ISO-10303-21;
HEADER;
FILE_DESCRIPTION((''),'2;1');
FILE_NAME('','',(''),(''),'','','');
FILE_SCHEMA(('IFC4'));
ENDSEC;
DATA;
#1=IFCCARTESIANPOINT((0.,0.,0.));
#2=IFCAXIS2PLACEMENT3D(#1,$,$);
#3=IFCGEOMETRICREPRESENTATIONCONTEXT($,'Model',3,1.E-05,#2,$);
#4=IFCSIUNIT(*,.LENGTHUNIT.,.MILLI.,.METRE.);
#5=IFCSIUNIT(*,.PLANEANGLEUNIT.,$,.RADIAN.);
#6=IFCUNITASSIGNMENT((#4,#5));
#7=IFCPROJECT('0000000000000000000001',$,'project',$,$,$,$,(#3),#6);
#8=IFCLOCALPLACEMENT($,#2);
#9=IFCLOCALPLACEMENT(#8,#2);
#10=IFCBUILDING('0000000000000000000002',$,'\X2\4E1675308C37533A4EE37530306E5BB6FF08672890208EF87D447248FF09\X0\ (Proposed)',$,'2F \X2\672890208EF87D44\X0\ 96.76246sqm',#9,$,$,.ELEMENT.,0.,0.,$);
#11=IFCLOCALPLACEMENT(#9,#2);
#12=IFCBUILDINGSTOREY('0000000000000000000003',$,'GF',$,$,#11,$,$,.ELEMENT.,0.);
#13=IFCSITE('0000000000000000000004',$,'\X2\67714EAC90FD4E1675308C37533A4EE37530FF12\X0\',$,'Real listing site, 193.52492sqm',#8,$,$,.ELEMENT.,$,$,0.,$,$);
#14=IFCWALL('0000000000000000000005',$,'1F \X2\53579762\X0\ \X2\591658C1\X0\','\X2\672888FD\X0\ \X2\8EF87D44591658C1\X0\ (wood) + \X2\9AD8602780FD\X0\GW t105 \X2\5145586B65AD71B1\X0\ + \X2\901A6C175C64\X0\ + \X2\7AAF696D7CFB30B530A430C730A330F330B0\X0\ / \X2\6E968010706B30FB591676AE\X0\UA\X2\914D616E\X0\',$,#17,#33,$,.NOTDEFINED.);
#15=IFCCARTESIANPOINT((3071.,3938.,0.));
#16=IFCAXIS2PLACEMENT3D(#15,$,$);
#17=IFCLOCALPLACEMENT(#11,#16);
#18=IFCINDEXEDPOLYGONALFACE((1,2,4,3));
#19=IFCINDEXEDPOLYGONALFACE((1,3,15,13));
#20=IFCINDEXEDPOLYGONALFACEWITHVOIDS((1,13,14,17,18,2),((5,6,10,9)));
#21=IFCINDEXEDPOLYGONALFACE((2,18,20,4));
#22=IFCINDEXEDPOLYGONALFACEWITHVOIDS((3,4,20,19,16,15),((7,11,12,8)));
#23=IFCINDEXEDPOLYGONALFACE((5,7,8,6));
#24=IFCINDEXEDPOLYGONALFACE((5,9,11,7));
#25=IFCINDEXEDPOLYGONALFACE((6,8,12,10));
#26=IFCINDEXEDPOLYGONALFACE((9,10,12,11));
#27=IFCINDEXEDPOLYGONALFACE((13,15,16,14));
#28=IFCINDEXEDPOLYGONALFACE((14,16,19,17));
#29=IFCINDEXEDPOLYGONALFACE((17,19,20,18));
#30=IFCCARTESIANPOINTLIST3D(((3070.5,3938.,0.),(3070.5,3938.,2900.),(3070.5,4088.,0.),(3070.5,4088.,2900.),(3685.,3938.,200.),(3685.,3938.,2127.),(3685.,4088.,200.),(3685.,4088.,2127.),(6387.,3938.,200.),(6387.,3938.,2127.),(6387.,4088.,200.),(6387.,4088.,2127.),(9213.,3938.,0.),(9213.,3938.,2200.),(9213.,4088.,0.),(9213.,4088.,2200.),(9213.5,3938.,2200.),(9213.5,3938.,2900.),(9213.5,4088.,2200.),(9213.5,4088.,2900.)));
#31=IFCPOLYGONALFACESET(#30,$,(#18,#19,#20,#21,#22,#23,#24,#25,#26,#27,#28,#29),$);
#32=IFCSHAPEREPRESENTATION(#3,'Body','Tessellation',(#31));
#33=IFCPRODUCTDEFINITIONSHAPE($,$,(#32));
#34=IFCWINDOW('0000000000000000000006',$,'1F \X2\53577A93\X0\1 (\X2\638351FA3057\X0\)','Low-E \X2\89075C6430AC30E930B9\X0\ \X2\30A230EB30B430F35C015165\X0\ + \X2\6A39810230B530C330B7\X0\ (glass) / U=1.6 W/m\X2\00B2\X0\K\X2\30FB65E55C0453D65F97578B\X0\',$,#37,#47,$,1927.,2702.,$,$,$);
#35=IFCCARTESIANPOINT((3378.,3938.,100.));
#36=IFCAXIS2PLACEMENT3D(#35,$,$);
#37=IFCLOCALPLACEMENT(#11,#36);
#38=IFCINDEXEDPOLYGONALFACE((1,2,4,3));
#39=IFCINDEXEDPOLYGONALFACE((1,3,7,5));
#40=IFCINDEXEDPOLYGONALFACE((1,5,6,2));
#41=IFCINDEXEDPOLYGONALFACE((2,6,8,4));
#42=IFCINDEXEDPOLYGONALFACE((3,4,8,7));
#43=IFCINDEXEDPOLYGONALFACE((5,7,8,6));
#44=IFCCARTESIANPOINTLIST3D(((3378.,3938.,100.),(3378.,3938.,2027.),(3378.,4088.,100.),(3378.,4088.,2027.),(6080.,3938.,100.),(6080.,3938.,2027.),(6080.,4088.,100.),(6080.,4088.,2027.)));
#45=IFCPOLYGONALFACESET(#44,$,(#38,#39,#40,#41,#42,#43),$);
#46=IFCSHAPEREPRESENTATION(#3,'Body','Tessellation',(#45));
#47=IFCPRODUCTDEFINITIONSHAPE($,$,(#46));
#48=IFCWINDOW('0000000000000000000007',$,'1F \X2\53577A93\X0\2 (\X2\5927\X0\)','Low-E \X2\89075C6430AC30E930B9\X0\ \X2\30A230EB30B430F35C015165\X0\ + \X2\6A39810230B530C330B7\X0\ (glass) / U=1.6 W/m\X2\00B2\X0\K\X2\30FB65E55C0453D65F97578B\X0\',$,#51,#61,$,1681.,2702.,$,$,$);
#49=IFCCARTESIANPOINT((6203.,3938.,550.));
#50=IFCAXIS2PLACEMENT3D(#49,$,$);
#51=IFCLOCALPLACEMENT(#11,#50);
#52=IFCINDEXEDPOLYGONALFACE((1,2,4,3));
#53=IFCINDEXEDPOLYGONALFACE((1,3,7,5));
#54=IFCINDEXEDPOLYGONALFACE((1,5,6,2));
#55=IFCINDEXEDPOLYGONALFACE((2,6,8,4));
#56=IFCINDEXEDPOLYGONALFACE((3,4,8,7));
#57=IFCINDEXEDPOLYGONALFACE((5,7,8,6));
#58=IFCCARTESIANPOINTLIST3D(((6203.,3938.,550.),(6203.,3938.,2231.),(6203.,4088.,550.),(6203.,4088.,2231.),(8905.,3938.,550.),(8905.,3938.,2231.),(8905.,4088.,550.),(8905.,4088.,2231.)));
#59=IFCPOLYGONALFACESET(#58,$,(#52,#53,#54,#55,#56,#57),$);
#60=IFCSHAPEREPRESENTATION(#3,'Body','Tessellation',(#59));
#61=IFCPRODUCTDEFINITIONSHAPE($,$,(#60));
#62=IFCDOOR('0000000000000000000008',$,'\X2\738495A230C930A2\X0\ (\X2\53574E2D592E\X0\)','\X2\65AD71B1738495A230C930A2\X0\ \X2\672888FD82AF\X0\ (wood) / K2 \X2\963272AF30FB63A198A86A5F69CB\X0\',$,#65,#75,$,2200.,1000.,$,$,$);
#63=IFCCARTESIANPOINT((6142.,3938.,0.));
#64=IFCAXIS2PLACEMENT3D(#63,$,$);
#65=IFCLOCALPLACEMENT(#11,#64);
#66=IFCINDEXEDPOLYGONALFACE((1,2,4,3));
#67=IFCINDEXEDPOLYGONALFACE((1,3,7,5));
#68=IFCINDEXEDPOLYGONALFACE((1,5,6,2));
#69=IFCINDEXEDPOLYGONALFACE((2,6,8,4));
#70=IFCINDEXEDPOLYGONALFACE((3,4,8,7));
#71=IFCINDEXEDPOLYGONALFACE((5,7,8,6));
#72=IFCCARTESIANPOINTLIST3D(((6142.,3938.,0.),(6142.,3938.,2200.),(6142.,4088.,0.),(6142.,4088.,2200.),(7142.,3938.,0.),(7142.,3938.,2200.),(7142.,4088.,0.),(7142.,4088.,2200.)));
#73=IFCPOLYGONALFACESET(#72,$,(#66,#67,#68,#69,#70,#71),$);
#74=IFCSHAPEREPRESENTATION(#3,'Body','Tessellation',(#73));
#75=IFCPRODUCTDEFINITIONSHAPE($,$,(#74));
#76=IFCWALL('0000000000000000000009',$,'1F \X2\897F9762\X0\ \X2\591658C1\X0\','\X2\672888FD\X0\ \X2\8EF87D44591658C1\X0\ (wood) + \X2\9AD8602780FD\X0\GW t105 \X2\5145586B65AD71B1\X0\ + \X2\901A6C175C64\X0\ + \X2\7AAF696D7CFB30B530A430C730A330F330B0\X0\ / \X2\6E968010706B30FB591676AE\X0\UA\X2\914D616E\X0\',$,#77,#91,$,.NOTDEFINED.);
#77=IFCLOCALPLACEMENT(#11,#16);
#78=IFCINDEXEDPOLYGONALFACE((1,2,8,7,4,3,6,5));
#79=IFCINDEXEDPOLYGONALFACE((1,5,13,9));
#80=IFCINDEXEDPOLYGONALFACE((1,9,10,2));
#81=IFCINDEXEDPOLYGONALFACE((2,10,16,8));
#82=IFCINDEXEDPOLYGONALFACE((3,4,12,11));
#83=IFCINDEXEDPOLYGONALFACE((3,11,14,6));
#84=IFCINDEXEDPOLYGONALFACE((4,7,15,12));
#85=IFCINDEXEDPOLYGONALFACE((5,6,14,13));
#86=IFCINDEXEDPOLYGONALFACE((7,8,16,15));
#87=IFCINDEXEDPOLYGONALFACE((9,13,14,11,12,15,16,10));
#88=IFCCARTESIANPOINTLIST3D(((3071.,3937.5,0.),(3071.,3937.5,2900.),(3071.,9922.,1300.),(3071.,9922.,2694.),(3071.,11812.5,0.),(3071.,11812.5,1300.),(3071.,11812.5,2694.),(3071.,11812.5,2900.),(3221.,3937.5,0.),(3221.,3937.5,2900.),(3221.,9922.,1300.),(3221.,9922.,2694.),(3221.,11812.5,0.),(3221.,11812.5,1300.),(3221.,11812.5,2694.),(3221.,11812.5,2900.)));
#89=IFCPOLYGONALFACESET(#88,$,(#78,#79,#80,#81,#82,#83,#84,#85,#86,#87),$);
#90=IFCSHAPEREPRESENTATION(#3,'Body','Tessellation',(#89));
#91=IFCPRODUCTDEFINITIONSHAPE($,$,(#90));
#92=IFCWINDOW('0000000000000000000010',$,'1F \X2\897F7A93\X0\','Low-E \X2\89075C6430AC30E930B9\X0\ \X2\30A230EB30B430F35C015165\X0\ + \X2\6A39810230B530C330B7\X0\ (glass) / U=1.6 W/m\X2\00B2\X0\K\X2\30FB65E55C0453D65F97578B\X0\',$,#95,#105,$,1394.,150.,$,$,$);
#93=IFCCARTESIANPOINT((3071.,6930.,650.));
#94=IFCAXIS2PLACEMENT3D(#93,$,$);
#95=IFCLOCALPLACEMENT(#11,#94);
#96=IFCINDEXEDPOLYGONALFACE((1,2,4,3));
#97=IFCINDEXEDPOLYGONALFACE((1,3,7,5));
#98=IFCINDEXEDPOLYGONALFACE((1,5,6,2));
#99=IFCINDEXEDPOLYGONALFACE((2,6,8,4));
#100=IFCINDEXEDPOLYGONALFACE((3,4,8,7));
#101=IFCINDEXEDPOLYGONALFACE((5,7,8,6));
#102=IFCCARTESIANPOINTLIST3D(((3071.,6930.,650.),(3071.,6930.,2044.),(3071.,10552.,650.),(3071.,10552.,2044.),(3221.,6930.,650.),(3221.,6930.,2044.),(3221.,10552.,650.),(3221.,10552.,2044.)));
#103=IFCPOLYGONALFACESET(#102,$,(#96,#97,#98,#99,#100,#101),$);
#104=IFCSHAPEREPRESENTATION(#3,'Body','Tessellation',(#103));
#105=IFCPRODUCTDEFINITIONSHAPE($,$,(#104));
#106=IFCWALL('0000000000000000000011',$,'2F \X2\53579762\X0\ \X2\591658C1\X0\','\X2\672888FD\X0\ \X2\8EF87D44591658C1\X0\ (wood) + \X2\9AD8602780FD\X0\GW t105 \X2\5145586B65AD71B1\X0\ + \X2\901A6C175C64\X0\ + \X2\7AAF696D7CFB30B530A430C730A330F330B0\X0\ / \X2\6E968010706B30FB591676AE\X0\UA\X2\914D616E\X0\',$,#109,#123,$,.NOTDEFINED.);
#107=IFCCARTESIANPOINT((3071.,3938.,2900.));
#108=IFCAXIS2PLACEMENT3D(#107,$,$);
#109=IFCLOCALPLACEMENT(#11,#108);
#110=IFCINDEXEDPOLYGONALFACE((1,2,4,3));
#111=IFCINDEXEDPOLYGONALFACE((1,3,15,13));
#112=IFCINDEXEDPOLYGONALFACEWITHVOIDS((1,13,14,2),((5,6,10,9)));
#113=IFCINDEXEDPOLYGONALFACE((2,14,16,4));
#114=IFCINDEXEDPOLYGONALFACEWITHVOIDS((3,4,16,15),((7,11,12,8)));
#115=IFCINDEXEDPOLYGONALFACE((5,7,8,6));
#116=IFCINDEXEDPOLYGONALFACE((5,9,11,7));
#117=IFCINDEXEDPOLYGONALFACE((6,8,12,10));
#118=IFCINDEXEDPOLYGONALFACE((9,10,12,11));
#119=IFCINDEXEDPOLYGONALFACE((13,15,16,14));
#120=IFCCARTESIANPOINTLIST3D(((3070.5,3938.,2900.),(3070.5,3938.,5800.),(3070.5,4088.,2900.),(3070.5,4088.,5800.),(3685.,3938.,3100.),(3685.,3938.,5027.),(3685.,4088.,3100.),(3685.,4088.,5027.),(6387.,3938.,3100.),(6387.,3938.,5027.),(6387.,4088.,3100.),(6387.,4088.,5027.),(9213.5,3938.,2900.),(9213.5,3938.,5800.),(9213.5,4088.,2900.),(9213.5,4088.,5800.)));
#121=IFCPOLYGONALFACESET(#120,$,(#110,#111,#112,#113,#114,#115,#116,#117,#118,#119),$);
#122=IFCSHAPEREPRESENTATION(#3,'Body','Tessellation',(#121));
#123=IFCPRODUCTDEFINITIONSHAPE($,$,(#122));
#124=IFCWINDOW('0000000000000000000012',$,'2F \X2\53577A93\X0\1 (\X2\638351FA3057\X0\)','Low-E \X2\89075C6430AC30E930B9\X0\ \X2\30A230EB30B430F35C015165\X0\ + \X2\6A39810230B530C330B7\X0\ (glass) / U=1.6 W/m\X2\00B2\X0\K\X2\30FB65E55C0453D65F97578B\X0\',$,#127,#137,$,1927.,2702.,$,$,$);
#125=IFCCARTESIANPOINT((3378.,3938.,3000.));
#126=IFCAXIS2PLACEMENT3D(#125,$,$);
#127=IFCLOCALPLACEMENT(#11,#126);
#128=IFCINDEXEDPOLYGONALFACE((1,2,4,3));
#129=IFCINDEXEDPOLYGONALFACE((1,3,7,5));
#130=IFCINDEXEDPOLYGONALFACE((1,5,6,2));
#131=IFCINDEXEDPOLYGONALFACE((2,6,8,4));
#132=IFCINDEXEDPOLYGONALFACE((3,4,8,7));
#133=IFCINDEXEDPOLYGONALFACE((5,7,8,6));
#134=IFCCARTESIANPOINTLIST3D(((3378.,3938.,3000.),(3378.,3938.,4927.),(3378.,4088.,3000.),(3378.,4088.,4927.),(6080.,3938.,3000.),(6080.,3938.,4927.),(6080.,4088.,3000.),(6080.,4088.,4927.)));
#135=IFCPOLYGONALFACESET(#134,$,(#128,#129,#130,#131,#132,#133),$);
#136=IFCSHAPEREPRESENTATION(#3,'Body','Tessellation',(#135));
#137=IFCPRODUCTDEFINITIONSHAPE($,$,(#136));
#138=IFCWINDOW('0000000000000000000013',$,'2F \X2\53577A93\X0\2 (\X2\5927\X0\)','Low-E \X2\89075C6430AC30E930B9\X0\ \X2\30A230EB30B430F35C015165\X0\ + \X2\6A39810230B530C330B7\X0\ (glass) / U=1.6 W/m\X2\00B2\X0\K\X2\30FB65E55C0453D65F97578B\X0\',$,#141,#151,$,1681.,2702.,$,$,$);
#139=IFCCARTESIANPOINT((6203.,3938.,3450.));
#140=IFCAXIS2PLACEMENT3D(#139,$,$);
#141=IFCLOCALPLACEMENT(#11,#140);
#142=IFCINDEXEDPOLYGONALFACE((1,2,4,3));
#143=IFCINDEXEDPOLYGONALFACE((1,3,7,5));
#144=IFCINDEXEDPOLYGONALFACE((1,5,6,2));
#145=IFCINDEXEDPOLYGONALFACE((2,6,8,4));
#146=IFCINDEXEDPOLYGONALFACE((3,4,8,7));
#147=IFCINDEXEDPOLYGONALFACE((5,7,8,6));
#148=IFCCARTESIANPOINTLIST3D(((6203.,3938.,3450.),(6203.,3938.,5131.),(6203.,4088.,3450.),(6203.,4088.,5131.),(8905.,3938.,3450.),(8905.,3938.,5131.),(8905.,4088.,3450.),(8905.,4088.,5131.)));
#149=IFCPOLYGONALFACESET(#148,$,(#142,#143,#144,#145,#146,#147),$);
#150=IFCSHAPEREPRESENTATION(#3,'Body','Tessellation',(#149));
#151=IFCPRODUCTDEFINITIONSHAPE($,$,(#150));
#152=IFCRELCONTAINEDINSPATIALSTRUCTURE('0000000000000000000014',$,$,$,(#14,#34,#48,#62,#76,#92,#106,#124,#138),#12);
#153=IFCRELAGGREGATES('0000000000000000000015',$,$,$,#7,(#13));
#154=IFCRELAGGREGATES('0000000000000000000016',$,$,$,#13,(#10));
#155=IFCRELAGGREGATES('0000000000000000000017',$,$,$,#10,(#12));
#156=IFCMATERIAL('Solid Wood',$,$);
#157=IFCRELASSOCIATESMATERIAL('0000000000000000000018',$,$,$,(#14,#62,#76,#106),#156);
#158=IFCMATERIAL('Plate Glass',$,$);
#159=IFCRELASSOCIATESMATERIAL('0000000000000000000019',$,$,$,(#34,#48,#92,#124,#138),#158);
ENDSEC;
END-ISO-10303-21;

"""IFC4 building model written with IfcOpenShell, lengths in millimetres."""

from ifc_helpers import new_model, si_unit, frame, frame_2d, origin, place, context, project, spatial, rectangle, extrude, material, element, fill, save


model = new_model("IFC4")

# Units and contexts
model_context = context("Model", 3, precision=1e-05, world=origin())
ifc_project = project(units=[si_unit("LENGTHUNIT", "METRE", prefix="MILLI"), si_unit("PLANEANGLEUNIT", "RADIAN")], contexts=[model_context])

# Site, building, storey
site_placement = place(None, origin())
site = spatial("IfcSite", under=ifc_project, at=site_placement, Name="東京都世田谷区代田２", ObjectType="Real listing site, 193.52492sqm", CompositionType="ELEMENT", RefElevation=0.0)
building_placement = place(site_placement, origin())
building = spatial("IfcBuilding", under=site, at=building_placement, Name="世田谷区代田の家（木造軸組版） (Proposed)", ObjectType="2F 木造軸組 96.76246sqm", CompositionType="ELEMENT", ElevationOfRefHeight=0.0, ElevationOfTerrain=0.0)
storey_placement = place(building_placement, origin())
storey = spatial("IfcBuildingStorey", under=building, at=storey_placement, Name="GF", CompositionType="ELEMENT", Elevation=0.0)

# Shared definitions
ifc_material_1 = material(Name="Solid Wood")

# Wall, openings, windows, door
wall_1_placement = place(storey_placement, frame((3071.0, 3938.0, 0.0)))
wall_1 = element("IfcWall", 1, at=wall_1_placement, inside=storey, material=ifc_material_1, Name="1F 南面 外壁", Description="木製 軸組外壁 (wood) + 高性能GW t105 充填断熱 + 通気層 + 窯業系サイディング / 準耐火・外皮UA配慮", PredefinedType="NOTDEFINED", context=model_context, shape_type="SweptSolid", body=[
    extrude(rectangle(XDim=6143.0, YDim=150.0, at=frame_2d((3071.0, 75.0))), frame((3071.0, 3938.0, 0.0)), (0.0, 0.0, 1.0), 2900.0),
])
opening_1_placement = place(storey_placement, frame((3378.0, 3938.0, 100.0)))
opening_1 = element("IfcOpeningElement", 2, at=opening_1_placement, cuts=wall_1, PredefinedType="NOTDEFINED", context=model_context, shape_type="SweptSolid", body=[
    extrude(rectangle(XDim=2702.0, YDim=150.0, at=frame_2d((1351.0, 75.0))), frame((3378.0, 3938.0, 100.0)), (0.0, 0.0, 1.0), 1927.0),
])
opening_2_placement = place(storey_placement, frame((6203.0, 3938.0, 550.0)))
opening_2 = element("IfcOpeningElement", 3, at=opening_2_placement, cuts=wall_1, PredefinedType="NOTDEFINED", context=model_context, shape_type="SweptSolid", body=[
    extrude(rectangle(XDim=2702.0, YDim=150.0, at=frame_2d((1351.0, 75.0))), frame((6203.0, 3938.0, 550.0)), (0.0, 0.0, 1.0), 1681.0),
])
opening_3_placement = place(storey_placement, frame((6142.0, 3938.0, 0.0)))
opening_3 = element("IfcOpeningElement", 4, at=opening_3_placement, cuts=wall_1, PredefinedType="NOTDEFINED", context=model_context, shape_type="SweptSolid", body=[
    extrude(rectangle(XDim=1000.0, YDim=150.0, at=frame_2d((500.0, 75.0))), frame((6142.0, 3938.0, 0.0)), (0.0, 0.0, 1.0), 2200.0),
])
ifc_material_2 = material(Name="Plate Glass")
window_1_placement = place(storey_placement, frame((3378.0, 3938.0, 100.0)))
window_1 = element("IfcWindow", 5, at=window_1_placement, inside=storey, material=ifc_material_2, Name="1F 南窓1 (掃出し)", Description="Low-E 複層ガラス アルゴン封入 + 樹脂サッシ (glass) / U=1.6 W/m²K・日射取得型", OverallHeight=1927.0, OverallWidth=2702.0, context=model_context, shape_type="SweptSolid", body=[
    extrude(rectangle(XDim=2702.0, YDim=150.0, at=frame_2d((1351.0, 75.0))), frame((3378.0, 3938.0, 100.0)), (0.0, 0.0, 1.0), 1927.0),
])
fill(opening_1, window_1)
window_2_placement = place(storey_placement, frame((6203.0, 3938.0, 550.0)))
window_2 = element("IfcWindow", 6, at=window_2_placement, inside=storey, material=ifc_material_2, Name="1F 南窓2 (大)", Description="Low-E 複層ガラス アルゴン封入 + 樹脂サッシ (glass) / U=1.6 W/m²K・日射取得型", OverallHeight=1681.0, OverallWidth=2702.0, context=model_context, shape_type="SweptSolid", body=[
    extrude(rectangle(XDim=2702.0, YDim=150.0, at=frame_2d((1351.0, 75.0))), frame((6203.0, 3938.0, 550.0)), (0.0, 0.0, 1.0), 1681.0),
])
fill(opening_2, window_2)
door_placement = place(storey_placement, frame((6142.0, 3938.0, 0.0)))
door = element("IfcDoor", 7, at=door_placement, inside=storey, material=ifc_material_1, Name="玄関ドア (南中央)", Description="断熱玄関ドア 木製芯 (wood) / K2 防犯・採風機構", OverallHeight=2200.0, OverallWidth=1000.0, context=model_context, shape_type="SweptSolid", body=[
    extrude(rectangle(XDim=1000.0, YDim=150.0, at=frame_2d((500.0, 75.0))), frame((6142.0, 3938.0, 0.0)), (0.0, 0.0, 1.0), 2200.0),
])
fill(opening_3, door)

# Wall, opening, window
wall_2_placement = place(storey_placement, frame((3071.0, 3938.0, 0.0)))
wall_2 = element("IfcWall", 8, at=wall_2_placement, inside=storey, material=ifc_material_1, Name="1F 西面 外壁", Description="木製 軸組外壁 (wood) + 高性能GW t105 充填断熱 + 通気層 + 窯業系サイディング / 準耐火・外皮UA配慮", PredefinedType="NOTDEFINED", context=model_context, shape_type="SweptSolid", body=[
    extrude(rectangle(XDim=150.0, YDim=7875.0, at=frame_2d((75.0, 3937.0))), frame((3071.0, 3938.0, 0.0)), (0.0, 0.0, 1.0), 2900.0),
])
opening_4_placement = place(storey_placement, frame((3071.0, 6930.0, 650.0)))
opening_4 = element("IfcOpeningElement", 9, at=opening_4_placement, cuts=wall_2, PredefinedType="NOTDEFINED", context=model_context, shape_type="SweptSolid", body=[
    extrude(rectangle(XDim=150.0, YDim=3622.0, at=frame_2d((75.0, 1811.0))), frame((3071.0, 6930.0, 650.0)), (0.0, 0.0, 1.0), 1394.0),
])
window_3_placement = place(storey_placement, frame((3071.0, 6930.0, 650.0)))
window_3 = element("IfcWindow", 10, at=window_3_placement, inside=storey, material=ifc_material_2, Name="1F 西窓", Description="Low-E 複層ガラス アルゴン封入 + 樹脂サッシ (glass) / U=1.6 W/m²K・日射取得型", OverallHeight=1394.0, OverallWidth=150.0, context=model_context, shape_type="SweptSolid", body=[
    extrude(rectangle(XDim=150.0, YDim=3622.0, at=frame_2d((75.0, 1811.0))), frame((3071.0, 6930.0, 650.0)), (0.0, 0.0, 1.0), 1394.0),
])
fill(opening_4, window_3)

# Wall, openings, windows
wall_3_placement = place(storey_placement, frame((3071.0, 3938.0, 2900.0)))
wall_3 = element("IfcWall", 11, at=wall_3_placement, inside=storey, material=ifc_material_1, Name="2F 南面 外壁", Description="木製 軸組外壁 (wood) + 高性能GW t105 充填断熱 + 通気層 + 窯業系サイディング / 準耐火・外皮UA配慮", PredefinedType="NOTDEFINED", context=model_context, shape_type="SweptSolid", body=[
    extrude(rectangle(XDim=6143.0, YDim=150.0, at=frame_2d((3071.0, 75.0))), frame((3071.0, 3938.0, 2900.0)), (0.0, 0.0, 1.0), 2900.0),
])
opening_5_placement = place(storey_placement, frame((3378.0, 3938.0, 3000.0)))
opening_5 = element("IfcOpeningElement", 12, at=opening_5_placement, cuts=wall_3, PredefinedType="NOTDEFINED", context=model_context, shape_type="SweptSolid", body=[
    extrude(rectangle(XDim=2702.0, YDim=150.0, at=frame_2d((1351.0, 75.0))), frame((3378.0, 3938.0, 3000.0)), (0.0, 0.0, 1.0), 1927.0),
])
opening_6_placement = place(storey_placement, frame((6203.0, 3938.0, 3450.0)))
opening_6 = element("IfcOpeningElement", 13, at=opening_6_placement, cuts=wall_3, PredefinedType="NOTDEFINED", context=model_context, shape_type="SweptSolid", body=[
    extrude(rectangle(XDim=2702.0, YDim=150.0, at=frame_2d((1351.0, 75.0))), frame((6203.0, 3938.0, 3450.0)), (0.0, 0.0, 1.0), 1681.0),
])
window_4_placement = place(storey_placement, frame((3378.0, 3938.0, 3000.0)))
window_4 = element("IfcWindow", 14, at=window_4_placement, inside=storey, material=ifc_material_2, Name="2F 南窓1 (掃出し)", Description="Low-E 複層ガラス アルゴン封入 + 樹脂サッシ (glass) / U=1.6 W/m²K・日射取得型", OverallHeight=1927.0, OverallWidth=2702.0, context=model_context, shape_type="SweptSolid", body=[
    extrude(rectangle(XDim=2702.0, YDim=150.0, at=frame_2d((1351.0, 75.0))), frame((3378.0, 3938.0, 3000.0)), (0.0, 0.0, 1.0), 1927.0),
])
fill(opening_5, window_4)
window_5_placement = place(storey_placement, frame((6203.0, 3938.0, 3450.0)))
window_5 = element("IfcWindow", 15, at=window_5_placement, inside=storey, material=ifc_material_2, Name="2F 南窓2 (大)", Description="Low-E 複層ガラス アルゴン封入 + 樹脂サッシ (glass) / U=1.6 W/m²K・日射取得型", OverallHeight=1681.0, OverallWidth=2702.0, context=model_context, shape_type="SweptSolid", body=[
    extrude(rectangle(XDim=2702.0, YDim=150.0, at=frame_2d((1351.0, 75.0))), frame((6203.0, 3938.0, 3450.0)), (0.0, 0.0, 1.0), 1681.0),
])
fill(opening_6, window_5)

save(model, "model.ifc")
